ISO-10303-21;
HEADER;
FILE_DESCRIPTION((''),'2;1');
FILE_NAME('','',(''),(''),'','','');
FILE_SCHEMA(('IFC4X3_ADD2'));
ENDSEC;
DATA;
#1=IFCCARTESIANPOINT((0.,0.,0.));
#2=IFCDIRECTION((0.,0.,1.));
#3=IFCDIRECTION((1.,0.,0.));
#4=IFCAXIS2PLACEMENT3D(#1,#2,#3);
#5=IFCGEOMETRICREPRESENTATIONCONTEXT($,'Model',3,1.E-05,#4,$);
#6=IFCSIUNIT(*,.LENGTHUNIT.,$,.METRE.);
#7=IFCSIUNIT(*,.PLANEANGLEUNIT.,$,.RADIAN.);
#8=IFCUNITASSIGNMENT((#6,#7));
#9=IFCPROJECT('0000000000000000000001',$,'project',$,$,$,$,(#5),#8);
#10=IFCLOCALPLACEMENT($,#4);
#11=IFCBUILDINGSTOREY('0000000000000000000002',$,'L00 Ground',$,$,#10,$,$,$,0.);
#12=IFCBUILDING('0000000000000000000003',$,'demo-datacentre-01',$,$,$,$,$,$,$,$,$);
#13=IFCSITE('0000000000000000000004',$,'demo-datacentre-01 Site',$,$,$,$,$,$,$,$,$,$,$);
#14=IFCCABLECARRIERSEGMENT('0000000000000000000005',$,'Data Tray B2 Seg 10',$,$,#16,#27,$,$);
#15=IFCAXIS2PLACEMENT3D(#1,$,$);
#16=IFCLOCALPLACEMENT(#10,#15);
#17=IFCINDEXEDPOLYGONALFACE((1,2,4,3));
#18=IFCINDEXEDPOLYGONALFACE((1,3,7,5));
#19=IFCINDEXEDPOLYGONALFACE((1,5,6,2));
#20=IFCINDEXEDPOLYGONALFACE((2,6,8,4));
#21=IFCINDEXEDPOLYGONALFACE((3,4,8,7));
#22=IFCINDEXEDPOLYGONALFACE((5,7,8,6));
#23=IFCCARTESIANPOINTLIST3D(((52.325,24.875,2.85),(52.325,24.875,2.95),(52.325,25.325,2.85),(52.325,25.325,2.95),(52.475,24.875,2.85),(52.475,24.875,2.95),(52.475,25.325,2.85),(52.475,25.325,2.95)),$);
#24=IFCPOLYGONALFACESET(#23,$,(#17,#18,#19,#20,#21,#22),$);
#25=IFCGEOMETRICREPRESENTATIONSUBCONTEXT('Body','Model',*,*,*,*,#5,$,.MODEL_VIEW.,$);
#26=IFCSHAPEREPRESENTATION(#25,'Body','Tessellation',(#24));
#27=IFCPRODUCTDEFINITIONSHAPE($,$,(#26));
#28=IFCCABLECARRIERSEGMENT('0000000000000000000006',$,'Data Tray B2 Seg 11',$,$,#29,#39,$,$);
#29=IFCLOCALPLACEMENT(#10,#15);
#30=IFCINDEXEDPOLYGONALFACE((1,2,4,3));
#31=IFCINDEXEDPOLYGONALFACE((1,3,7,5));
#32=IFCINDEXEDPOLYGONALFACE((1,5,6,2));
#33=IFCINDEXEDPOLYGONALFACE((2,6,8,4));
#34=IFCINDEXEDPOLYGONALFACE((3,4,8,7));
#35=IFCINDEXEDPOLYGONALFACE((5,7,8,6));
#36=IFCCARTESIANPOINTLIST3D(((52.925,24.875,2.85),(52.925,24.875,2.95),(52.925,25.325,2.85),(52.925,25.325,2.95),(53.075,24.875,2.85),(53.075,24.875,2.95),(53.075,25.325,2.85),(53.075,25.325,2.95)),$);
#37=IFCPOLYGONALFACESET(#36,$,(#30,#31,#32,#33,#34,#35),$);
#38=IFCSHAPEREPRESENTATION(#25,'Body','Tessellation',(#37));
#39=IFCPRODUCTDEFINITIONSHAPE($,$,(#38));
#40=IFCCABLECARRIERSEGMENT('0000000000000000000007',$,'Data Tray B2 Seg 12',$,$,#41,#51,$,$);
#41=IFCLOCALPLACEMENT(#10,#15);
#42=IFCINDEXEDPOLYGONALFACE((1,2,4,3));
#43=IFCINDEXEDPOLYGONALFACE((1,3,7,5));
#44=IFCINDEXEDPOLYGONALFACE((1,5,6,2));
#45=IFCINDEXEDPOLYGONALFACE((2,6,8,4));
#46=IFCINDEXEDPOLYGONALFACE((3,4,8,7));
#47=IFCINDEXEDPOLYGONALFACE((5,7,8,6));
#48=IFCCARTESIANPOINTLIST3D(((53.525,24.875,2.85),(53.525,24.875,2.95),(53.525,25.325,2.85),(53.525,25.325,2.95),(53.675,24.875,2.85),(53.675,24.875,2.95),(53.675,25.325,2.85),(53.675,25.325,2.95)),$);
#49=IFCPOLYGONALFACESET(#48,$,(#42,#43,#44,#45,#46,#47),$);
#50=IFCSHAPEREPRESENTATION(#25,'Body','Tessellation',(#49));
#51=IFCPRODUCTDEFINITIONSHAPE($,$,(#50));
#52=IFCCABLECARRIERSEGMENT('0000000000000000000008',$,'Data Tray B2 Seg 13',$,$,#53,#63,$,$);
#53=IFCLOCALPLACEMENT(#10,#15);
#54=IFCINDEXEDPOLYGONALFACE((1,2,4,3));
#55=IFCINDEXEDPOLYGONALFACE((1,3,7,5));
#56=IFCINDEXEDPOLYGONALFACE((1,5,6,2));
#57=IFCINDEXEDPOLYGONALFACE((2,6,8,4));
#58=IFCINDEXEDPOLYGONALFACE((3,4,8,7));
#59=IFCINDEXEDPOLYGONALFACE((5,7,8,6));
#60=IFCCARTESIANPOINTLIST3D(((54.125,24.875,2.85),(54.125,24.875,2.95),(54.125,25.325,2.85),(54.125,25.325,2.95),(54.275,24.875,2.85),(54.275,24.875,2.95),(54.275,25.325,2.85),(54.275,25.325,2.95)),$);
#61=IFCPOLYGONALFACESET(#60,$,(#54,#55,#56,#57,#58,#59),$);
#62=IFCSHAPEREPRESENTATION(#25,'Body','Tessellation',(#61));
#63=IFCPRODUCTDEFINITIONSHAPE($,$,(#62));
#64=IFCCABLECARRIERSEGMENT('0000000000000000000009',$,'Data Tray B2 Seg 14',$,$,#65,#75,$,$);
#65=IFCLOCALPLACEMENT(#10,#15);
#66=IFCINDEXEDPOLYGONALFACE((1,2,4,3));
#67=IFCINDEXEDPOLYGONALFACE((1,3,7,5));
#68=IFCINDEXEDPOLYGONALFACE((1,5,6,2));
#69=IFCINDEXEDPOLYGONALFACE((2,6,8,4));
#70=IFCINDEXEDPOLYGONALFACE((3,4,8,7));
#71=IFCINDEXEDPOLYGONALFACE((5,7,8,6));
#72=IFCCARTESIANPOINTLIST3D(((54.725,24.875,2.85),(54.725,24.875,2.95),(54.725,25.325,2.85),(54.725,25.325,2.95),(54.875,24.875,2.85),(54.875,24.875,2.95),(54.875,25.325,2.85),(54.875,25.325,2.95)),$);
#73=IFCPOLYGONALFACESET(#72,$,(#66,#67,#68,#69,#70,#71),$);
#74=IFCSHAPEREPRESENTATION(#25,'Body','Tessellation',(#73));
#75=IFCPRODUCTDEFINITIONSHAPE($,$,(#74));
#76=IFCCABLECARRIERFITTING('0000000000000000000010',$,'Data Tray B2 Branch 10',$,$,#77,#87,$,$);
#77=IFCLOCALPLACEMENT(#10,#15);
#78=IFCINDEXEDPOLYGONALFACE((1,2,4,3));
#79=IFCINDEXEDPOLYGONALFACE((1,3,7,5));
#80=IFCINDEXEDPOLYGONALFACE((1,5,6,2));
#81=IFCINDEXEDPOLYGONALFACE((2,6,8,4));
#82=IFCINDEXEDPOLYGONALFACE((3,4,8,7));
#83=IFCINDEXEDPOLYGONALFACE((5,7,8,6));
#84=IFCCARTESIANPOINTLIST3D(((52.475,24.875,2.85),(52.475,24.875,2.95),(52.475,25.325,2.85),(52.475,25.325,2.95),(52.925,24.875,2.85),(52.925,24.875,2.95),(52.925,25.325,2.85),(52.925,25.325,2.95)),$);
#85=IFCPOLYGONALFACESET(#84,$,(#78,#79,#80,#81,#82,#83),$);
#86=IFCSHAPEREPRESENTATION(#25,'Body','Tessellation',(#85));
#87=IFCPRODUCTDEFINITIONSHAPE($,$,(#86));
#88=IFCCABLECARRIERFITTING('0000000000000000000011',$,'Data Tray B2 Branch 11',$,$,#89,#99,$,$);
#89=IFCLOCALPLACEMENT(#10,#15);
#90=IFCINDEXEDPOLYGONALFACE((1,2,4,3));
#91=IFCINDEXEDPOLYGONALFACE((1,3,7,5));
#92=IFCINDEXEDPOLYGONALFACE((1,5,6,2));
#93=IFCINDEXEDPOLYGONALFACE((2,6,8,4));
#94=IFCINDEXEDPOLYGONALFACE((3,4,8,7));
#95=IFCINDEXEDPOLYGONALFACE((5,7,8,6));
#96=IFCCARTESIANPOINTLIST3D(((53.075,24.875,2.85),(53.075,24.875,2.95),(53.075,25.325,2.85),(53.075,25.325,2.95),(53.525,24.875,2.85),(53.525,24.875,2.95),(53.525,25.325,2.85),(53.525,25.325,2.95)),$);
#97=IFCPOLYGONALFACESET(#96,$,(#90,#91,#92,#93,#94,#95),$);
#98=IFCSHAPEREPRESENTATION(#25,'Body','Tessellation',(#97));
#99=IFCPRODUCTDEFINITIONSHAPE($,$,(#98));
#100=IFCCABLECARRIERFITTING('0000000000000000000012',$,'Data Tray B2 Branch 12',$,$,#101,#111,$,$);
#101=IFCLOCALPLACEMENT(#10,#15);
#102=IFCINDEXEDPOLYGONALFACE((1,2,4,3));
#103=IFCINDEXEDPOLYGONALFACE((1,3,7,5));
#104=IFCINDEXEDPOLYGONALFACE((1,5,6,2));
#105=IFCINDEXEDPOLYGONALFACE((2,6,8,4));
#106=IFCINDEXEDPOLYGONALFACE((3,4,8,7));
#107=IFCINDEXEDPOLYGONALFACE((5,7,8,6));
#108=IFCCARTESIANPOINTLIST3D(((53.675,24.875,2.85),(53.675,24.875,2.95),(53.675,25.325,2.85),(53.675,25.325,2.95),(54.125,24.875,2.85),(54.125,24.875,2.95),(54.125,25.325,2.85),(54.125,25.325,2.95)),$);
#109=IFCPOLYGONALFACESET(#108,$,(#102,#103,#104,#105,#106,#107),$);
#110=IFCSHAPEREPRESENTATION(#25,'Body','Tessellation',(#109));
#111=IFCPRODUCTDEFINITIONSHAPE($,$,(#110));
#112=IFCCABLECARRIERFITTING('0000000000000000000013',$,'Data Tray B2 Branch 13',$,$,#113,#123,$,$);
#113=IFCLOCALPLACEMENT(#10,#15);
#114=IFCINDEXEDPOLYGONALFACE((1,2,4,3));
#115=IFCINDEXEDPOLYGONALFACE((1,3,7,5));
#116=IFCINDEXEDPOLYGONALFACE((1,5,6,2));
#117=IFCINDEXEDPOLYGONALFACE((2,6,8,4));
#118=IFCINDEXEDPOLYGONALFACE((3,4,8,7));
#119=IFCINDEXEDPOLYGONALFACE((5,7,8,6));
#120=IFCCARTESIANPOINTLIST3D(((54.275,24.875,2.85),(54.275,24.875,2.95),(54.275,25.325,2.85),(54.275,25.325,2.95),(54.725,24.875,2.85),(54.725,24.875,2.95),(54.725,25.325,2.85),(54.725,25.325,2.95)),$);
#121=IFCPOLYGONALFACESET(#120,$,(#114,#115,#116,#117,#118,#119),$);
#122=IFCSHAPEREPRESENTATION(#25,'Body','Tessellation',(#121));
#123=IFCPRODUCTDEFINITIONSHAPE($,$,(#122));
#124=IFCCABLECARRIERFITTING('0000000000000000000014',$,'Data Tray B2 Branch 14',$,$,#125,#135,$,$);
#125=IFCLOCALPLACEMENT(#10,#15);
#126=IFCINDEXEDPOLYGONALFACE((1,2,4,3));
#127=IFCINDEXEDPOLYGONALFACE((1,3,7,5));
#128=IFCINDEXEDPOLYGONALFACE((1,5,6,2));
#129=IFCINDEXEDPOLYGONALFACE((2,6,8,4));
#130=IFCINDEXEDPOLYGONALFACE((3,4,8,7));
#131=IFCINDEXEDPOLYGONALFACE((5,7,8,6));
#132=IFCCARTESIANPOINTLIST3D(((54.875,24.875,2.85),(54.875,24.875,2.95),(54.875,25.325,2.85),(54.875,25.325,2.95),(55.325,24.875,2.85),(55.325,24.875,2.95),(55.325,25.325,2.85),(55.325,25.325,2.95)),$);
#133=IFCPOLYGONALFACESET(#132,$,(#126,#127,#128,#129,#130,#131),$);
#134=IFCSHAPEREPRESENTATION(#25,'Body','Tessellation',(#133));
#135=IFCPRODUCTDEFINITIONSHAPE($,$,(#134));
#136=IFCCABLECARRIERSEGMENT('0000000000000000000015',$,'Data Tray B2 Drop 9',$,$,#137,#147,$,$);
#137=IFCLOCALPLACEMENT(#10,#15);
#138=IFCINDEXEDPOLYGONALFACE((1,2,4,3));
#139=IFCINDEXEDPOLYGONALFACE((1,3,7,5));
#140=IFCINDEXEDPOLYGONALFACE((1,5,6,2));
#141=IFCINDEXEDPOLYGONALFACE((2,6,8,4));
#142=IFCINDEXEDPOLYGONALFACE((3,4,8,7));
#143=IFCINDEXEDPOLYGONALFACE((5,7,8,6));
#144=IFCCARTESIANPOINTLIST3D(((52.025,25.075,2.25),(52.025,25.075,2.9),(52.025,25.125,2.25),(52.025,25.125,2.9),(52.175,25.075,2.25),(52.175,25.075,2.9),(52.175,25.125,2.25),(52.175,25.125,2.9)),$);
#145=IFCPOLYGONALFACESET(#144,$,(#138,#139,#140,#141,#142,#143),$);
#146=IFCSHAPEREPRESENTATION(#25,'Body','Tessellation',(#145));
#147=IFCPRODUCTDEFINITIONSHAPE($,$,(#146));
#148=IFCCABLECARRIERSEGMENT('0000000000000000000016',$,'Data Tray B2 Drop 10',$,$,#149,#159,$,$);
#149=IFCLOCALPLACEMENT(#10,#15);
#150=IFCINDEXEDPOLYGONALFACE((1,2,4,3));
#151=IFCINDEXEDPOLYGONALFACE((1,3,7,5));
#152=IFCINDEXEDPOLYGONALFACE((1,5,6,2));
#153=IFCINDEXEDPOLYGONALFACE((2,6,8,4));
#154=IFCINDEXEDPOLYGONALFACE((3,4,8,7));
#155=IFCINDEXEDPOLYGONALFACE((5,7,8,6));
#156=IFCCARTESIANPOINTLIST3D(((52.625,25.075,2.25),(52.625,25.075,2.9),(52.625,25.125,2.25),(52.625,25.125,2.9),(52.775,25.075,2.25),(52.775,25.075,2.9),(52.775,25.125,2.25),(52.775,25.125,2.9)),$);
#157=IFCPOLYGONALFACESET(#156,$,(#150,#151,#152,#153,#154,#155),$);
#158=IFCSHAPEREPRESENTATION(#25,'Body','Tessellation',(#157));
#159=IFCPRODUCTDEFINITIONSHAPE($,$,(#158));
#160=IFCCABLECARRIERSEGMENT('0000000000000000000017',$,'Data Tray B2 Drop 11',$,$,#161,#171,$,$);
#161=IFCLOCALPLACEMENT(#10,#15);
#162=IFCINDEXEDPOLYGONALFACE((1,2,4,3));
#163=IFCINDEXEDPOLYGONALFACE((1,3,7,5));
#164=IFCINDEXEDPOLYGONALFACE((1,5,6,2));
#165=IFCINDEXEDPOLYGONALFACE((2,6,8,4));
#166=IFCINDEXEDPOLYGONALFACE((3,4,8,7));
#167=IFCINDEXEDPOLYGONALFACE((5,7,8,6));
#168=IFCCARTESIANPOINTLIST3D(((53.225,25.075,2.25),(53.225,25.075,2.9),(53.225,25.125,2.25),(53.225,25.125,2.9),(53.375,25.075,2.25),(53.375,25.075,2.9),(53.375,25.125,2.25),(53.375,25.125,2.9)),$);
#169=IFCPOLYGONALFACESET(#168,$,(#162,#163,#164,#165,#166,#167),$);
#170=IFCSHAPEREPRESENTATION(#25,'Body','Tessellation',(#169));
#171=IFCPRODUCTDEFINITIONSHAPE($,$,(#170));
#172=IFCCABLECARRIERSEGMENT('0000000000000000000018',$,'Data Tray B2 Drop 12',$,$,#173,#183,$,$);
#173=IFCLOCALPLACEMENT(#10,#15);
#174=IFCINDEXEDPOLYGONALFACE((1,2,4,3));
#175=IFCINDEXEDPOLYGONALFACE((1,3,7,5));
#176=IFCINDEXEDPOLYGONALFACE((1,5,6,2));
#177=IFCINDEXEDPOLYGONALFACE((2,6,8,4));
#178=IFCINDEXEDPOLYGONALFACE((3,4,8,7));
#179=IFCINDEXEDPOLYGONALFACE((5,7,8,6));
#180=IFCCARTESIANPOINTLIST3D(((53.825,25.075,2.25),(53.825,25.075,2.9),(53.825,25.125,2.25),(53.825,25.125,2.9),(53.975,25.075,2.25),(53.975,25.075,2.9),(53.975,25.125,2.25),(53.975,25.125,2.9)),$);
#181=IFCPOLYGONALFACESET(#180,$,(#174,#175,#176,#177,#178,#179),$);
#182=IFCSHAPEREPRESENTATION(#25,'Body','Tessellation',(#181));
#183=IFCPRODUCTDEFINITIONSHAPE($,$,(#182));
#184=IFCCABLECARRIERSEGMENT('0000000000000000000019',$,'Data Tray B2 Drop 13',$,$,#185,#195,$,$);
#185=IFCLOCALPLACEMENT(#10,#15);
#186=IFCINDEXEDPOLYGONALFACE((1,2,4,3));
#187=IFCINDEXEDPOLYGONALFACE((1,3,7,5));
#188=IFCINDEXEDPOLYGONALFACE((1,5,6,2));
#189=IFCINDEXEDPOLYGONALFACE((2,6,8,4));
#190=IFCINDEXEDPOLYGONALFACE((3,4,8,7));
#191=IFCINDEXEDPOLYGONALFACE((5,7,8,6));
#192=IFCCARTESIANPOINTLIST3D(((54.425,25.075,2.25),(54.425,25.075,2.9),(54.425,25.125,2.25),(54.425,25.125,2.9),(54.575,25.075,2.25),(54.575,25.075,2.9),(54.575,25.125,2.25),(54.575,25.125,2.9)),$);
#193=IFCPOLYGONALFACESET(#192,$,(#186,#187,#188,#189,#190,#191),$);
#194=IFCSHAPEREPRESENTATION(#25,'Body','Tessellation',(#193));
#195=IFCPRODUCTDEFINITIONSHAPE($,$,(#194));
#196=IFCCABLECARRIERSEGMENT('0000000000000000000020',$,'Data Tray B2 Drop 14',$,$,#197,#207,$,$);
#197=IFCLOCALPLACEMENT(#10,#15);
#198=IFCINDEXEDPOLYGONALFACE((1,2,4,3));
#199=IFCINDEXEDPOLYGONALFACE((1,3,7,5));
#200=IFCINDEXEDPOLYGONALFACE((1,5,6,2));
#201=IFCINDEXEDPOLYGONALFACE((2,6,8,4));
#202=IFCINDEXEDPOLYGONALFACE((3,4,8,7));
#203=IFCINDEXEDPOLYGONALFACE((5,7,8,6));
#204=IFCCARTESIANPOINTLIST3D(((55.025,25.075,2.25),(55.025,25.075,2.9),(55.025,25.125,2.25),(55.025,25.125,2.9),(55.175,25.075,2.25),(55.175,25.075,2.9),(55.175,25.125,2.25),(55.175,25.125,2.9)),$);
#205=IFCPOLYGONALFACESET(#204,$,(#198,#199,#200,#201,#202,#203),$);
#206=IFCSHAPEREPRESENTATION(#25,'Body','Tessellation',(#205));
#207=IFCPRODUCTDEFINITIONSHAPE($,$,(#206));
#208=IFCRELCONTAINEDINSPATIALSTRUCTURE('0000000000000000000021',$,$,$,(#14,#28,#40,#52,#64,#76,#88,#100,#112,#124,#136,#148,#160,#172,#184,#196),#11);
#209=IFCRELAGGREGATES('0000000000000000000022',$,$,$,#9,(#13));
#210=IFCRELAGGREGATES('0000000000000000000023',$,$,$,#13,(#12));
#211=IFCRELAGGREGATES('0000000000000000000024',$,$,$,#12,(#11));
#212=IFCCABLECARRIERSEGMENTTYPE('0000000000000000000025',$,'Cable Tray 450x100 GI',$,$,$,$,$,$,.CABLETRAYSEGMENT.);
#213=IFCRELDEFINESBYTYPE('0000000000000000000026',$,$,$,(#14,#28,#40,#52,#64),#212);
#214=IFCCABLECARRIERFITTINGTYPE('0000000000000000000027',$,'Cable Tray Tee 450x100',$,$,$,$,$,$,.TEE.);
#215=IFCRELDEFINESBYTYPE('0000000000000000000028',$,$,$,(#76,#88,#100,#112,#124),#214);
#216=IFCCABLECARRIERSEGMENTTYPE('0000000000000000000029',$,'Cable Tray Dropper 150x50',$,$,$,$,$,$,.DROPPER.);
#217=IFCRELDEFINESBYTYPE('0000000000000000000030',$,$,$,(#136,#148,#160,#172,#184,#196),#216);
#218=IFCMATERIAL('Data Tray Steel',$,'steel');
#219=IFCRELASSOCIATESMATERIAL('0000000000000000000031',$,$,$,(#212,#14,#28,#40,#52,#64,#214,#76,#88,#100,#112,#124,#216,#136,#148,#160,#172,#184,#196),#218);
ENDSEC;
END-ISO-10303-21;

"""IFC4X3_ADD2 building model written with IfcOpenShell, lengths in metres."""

from ifc_helpers import new_model, si_unit, frame, origin_with_axes, place, context, subcontext, project, spatial, rectangle, extrude, material, type_object, element, save


model = new_model("IFC4X3_ADD2")

# Units and contexts
model_context = context("Model", 3, precision=1e-05, world=origin_with_axes())
body_context = subcontext(model_context, "Body", "Model", "MODEL_VIEW")
ifc_project = project(units=[si_unit("LENGTHUNIT", "METRE"), si_unit("PLANEANGLEUNIT", "RADIAN")], contexts=[model_context])

# Site, building, storey
site = spatial("IfcSite", under=ifc_project, Name="demo-datacentre-01 Site")
building = spatial("IfcBuilding", under=site, Name="demo-datacentre-01")
storey_placement = place(None, origin_with_axes())
storey = spatial("IfcBuildingStorey", under=building, at=storey_placement, Name="L00 Ground", Elevation=0.0)

# Cable carrier segments
ifc_material_1 = material(Name="Data Tray Steel", Category="steel")
cable_carrier_segment_type_1 = type_object("IfcCableCarrierSegmentType", Name="Cable Tray 450x100 GI", PredefinedType="CABLETRAYSEGMENT", material=ifc_material_1)
for number, where, z_axis, x_axis, name in (
    (1, (52.325, 25.1, 2.9), (1.0, 0.0, 0.0), (0.0, 1.0, 0.0), "Data Tray B2 Seg 10"),
    (2, (52.925, 25.1, 2.9), (1.0, 0.0, 0.0), (0.0, 1.0, 0.0), "Data Tray B2 Seg 11"),
    (3, (53.525, 25.1, 2.9), (1.0, 0.0, 0.0), (0.0, 1.0, 0.0), "Data Tray B2 Seg 12"),
    (4, (54.125, 25.1, 2.9), (1.0, 0.0, 0.0), (0.0, 1.0, 0.0), "Data Tray B2 Seg 13"),
):
    element("IfcCableCarrierSegment", number, at=place(storey_placement, frame(where, z_axis=z_axis, x_axis=x_axis)), inside=storey, type_object=cable_carrier_segment_type_1, material=ifc_material_1, Name=name, context=body_context, shape_type="SweptSolid", body=[
        extrude(rectangle(XDim=0.45, YDim=0.1), origin_with_axes(), (0.0, 0.0, 1.0), 0.15),
    ])
cable_carrier_segment_placement = place(storey_placement, frame((54.725, 25.1, 2.9), z_axis=(1.0, 0.0, 0.0), x_axis=(0.0, 1.0, 0.0)))
element("IfcCableCarrierSegment", 5, at=cable_carrier_segment_placement, inside=storey, type_object=cable_carrier_segment_type_1, material=ifc_material_1, Name="Data Tray B2 Seg 14", context=body_context, shape_type="SweptSolid", body=[
    extrude(rectangle(XDim=0.45, YDim=0.1), origin_with_axes(), (0.0, 0.0, 1.0), 0.15),
])

# Cable carrier fittings
cable_carrier_fitting_type = type_object("IfcCableCarrierFittingType", Name="Cable Tray Tee 450x100", PredefinedType="TEE", material=ifc_material_1)
for number, where, z_axis, x_axis, name in (
    (6, (52.7, 25.1, 2.85), (0.0, 0.0, 1.0), (1.0, 0.0, 0.0), "Data Tray B2 Branch 10"),
    (7, (53.3, 25.1, 2.85), (0.0, 0.0, 1.0), (1.0, 0.0, 0.0), "Data Tray B2 Branch 11"),
    (8, (53.9, 25.1, 2.85), (0.0, 0.0, 1.0), (1.0, 0.0, 0.0), "Data Tray B2 Branch 12"),
    (9, (54.5, 25.1, 2.85), (0.0, 0.0, 1.0), (1.0, 0.0, 0.0), "Data Tray B2 Branch 13"),
    (10, (55.1, 25.1, 2.85), (0.0, 0.0, 1.0), (1.0, 0.0, 0.0), "Data Tray B2 Branch 14"),
):
    element("IfcCableCarrierFitting", number, at=place(storey_placement, frame(where, z_axis=z_axis, x_axis=x_axis)), inside=storey, type_object=cable_carrier_fitting_type, material=ifc_material_1, Name=name, context=body_context, shape_type="SweptSolid", body=[
        extrude(rectangle(XDim=0.45, YDim=0.45), origin_with_axes(), (0.0, 0.0, 1.0), 0.1),
    ])

# Cable carrier segments
cable_carrier_segment_type_2 = type_object("IfcCableCarrierSegmentType", Name="Cable Tray Dropper 150x50", PredefinedType="DROPPER", material=ifc_material_1)
for number, where, z_axis, x_axis, name in (
    (11, (52.1, 25.1, 2.9), (0.0, 0.0, -1.0), (1.0, 0.0, 0.0), "Data Tray B2 Drop 9"),
    (12, (52.7, 25.1, 2.9), (0.0, 0.0, -1.0), (1.0, 0.0, 0.0), "Data Tray B2 Drop 10"),
    (13, (53.3, 25.1, 2.9), (0.0, 0.0, -1.0), (1.0, 0.0, 0.0), "Data Tray B2 Drop 11"),
    (14, (53.9, 25.1, 2.9), (0.0, 0.0, -1.0), (1.0, 0.0, 0.0), "Data Tray B2 Drop 12"),
    (15, (54.5, 25.1, 2.9), (0.0, 0.0, -1.0), (1.0, 0.0, 0.0), "Data Tray B2 Drop 13"),
    (16, (55.1, 25.1, 2.9), (0.0, 0.0, -1.0), (1.0, 0.0, 0.0), "Data Tray B2 Drop 14"),
):
    element("IfcCableCarrierSegment", number, at=place(storey_placement, frame(where, z_axis=z_axis, x_axis=x_axis)), inside=storey, type_object=cable_carrier_segment_type_2, material=ifc_material_1, Name=name, context=body_context, shape_type="SweptSolid", body=[
        extrude(rectangle(XDim=0.15, YDim=0.05), origin_with_axes(), (0.0, 0.0, 1.0), 0.65),
    ])

save(model, "model.ifc")
